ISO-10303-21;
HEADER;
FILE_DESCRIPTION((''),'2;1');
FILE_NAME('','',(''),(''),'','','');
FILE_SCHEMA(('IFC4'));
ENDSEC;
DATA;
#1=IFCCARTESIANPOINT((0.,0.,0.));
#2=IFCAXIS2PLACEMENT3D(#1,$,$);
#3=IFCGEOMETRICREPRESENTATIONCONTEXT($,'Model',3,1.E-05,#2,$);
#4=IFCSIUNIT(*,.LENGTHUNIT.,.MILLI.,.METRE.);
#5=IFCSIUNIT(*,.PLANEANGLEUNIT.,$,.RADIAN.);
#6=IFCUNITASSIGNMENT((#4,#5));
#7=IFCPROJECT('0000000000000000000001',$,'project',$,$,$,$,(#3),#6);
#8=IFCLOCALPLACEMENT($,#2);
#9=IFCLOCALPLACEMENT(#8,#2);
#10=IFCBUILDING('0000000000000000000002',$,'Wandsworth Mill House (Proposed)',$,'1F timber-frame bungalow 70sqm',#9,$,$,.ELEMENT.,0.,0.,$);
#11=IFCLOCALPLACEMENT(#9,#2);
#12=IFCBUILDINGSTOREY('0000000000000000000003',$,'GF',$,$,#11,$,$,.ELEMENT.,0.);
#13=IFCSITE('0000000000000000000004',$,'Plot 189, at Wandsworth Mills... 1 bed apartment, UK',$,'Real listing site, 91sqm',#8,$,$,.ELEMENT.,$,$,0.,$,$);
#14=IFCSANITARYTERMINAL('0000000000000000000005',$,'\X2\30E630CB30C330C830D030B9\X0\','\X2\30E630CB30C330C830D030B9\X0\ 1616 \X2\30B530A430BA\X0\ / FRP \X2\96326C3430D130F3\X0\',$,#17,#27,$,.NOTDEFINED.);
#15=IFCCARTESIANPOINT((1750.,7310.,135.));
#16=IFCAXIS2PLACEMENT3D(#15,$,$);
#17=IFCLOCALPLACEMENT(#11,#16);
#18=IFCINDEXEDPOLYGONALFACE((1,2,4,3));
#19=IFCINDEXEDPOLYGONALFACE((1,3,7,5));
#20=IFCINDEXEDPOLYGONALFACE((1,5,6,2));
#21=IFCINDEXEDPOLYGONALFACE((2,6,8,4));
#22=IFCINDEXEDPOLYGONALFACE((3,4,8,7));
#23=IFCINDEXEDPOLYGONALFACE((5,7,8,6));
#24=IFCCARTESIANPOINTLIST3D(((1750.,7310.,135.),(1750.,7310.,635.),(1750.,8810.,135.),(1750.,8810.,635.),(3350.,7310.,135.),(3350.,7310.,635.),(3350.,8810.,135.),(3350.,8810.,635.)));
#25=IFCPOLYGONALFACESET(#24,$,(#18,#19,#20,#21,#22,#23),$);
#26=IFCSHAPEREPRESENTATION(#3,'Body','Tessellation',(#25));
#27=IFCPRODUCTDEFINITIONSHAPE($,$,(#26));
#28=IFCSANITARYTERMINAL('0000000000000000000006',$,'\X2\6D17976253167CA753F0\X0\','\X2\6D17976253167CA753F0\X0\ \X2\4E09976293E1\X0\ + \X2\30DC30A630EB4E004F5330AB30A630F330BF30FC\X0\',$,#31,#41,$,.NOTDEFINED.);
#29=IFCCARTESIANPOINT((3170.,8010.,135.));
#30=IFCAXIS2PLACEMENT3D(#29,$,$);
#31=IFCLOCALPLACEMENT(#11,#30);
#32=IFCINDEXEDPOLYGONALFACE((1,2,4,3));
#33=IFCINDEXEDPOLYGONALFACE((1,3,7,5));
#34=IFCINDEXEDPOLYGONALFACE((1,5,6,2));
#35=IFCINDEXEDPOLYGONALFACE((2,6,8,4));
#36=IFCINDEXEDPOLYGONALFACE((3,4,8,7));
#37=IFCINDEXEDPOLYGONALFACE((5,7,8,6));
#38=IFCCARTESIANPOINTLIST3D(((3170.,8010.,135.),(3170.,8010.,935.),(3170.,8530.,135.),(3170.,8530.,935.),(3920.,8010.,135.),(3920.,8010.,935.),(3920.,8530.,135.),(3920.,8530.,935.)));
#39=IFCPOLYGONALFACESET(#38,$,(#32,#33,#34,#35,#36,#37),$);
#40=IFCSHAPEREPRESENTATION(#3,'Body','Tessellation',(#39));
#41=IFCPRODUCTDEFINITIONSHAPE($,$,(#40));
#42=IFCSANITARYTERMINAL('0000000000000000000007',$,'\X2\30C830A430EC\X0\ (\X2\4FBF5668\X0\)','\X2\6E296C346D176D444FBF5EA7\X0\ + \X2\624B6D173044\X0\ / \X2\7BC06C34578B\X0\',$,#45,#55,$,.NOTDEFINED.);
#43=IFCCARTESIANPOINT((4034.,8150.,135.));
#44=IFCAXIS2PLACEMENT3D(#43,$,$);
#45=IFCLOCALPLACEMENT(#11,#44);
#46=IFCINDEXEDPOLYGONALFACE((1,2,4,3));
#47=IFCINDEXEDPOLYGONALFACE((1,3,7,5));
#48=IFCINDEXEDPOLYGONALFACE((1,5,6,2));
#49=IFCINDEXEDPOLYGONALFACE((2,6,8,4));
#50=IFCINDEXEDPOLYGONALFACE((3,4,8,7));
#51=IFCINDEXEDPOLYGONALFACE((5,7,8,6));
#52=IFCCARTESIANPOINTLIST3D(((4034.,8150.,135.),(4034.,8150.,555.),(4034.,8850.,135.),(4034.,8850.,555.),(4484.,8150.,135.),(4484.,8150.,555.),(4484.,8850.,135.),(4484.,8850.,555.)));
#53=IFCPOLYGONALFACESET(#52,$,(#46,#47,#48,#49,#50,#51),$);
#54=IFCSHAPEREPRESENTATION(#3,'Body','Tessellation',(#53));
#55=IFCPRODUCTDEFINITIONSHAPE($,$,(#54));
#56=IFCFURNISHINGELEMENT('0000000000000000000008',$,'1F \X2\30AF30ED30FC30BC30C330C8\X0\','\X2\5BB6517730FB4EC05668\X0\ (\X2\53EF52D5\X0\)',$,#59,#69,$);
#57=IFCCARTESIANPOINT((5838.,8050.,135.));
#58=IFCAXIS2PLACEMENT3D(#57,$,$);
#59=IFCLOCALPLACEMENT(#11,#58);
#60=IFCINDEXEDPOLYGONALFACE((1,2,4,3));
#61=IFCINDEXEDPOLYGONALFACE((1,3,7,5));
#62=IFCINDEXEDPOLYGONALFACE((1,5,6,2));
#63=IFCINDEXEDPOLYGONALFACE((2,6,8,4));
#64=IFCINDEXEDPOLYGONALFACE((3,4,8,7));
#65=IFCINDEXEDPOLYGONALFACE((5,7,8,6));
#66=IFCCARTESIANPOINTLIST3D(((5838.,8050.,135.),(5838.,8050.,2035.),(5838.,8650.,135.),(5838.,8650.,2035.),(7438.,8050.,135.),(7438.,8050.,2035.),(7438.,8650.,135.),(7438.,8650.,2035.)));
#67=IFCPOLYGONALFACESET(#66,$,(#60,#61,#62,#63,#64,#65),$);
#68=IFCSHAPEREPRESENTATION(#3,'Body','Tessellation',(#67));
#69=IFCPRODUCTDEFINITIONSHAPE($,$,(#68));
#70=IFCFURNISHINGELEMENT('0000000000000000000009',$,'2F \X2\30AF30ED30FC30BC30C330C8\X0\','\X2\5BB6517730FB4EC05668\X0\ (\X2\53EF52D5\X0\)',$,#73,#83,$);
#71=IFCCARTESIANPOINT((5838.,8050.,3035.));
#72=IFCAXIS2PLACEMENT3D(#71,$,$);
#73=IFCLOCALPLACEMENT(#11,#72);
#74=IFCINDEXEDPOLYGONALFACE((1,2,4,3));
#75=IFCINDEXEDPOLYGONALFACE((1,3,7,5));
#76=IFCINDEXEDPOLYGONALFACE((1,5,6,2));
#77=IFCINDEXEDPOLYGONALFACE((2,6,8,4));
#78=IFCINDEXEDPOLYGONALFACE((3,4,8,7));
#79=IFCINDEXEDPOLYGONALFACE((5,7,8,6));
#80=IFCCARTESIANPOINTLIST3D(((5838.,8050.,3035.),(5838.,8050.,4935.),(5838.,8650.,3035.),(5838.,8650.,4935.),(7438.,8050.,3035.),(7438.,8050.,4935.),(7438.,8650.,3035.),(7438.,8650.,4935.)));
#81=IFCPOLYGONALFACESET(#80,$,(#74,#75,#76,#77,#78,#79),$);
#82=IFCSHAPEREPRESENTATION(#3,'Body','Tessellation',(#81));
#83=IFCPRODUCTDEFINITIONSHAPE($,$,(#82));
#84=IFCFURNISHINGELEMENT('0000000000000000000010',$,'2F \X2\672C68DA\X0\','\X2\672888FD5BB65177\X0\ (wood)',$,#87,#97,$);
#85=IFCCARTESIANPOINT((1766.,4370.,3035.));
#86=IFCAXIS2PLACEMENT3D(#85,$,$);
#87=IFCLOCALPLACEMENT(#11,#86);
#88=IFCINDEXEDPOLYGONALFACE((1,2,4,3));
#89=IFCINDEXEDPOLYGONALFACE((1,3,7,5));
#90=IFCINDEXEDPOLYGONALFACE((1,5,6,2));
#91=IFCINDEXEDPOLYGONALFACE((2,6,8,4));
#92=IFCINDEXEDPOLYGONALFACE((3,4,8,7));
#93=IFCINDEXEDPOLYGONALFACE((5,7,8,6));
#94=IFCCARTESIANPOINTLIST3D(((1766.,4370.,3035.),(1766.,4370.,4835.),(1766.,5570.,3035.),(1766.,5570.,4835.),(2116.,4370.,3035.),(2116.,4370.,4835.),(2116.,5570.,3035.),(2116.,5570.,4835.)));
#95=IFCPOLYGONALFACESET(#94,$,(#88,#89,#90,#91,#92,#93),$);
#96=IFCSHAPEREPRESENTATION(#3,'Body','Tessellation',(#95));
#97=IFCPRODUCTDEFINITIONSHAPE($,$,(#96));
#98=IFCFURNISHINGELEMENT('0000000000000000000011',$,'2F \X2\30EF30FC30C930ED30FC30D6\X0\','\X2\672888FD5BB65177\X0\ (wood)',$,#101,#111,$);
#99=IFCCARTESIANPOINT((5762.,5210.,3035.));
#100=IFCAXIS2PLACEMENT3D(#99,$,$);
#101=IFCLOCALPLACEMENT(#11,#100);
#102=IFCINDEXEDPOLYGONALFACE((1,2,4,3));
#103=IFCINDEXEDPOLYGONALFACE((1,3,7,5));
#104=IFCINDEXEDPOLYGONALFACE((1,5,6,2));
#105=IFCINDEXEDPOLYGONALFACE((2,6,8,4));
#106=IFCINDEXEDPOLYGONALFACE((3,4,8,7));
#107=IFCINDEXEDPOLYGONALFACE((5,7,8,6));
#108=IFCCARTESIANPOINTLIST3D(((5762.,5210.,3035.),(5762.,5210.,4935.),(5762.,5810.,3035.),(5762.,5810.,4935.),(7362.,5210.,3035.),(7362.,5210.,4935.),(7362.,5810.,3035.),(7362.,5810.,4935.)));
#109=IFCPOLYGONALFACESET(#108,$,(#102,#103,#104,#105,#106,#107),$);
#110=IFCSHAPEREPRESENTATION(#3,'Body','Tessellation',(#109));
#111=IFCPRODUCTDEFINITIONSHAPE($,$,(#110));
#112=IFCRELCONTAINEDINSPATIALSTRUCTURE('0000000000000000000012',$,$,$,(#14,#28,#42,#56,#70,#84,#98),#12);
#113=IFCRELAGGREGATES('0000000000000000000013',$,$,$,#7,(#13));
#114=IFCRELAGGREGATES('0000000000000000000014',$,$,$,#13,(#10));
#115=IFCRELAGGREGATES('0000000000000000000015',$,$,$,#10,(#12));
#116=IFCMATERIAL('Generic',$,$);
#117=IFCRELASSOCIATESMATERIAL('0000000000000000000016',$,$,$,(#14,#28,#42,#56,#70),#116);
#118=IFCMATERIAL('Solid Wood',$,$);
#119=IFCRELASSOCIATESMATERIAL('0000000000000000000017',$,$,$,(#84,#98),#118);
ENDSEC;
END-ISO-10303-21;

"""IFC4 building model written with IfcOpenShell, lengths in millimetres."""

from ifc_helpers import new_model, si_unit, frame, frame_2d, origin, place, context, project, spatial, rectangle, extrude, material, element, save


model = new_model("IFC4")

# Units and contexts
model_context = context("Model", 3, precision=1e-05, world=origin())
ifc_project = project(units=[si_unit("LENGTHUNIT", "METRE", prefix="MILLI"), si_unit("PLANEANGLEUNIT", "RADIAN")], contexts=[model_context])

# Site, building, storey
site_placement = place(None, origin())
site = spatial("IfcSite", under=ifc_project, at=site_placement, Name="Plot 189, at Wandsworth Mills... 1 bed apartment, UK", ObjectType="Real listing site, 91sqm", CompositionType="ELEMENT", RefElevation=0.0)
building_placement = place(site_placement, origin())
building = spatial("IfcBuilding", under=site, at=building_placement, Name="Wandsworth Mill House (Proposed)", ObjectType="1F timber-frame bungalow 70sqm", CompositionType="ELEMENT", ElevationOfRefHeight=0.0, ElevationOfTerrain=0.0)
storey_placement = place(building_placement, origin())
storey = spatial("IfcBuildingStorey", under=building, at=storey_placement, Name="GF", CompositionType="ELEMENT", Elevation=0.0)

# Shared definitions
ifc_material_1 = material(Name="Solid Wood")

# Shared definitions
ifc_material_2 = material(Name="Generic")

# Sanitary terminals
sanitary_terminal_1_placement = place(storey_placement, frame((1750.0, 7310.0, 135.0)))
element("IfcSanitaryTerminal", 1, at=sanitary_terminal_1_placement, inside=storey, material=ifc_material_2, Name="ユニットバス", Description="ユニットバス 1616 サイズ / FRP 防水パン", PredefinedType="NOTDEFINED", context=model_context, shape_type="SweptSolid", body=[
    extrude(rectangle(XDim=1600.0, YDim=1500.0, at=frame_2d((800.0, 750.0))), frame((1750.0, 7310.0, 135.0)), (0.0, 0.0, 1.0), 500.0),
])
sanitary_terminal_2_placement = place(storey_placement, frame((3170.0, 8010.0, 135.0)))
element("IfcSanitaryTerminal", 2, at=sanitary_terminal_2_placement, inside=storey, material=ifc_material_2, Name="洗面化粧台", Description="洗面化粧台 三面鏡 + ボウル一体カウンター", PredefinedType="NOTDEFINED", context=model_context, shape_type="SweptSolid", body=[
    extrude(rectangle(XDim=750.0, YDim=520.0, at=frame_2d((375.0, 260.0))), frame((3170.0, 8010.0, 135.0)), (0.0, 0.0, 1.0), 800.0),
])
sanitary_terminal_3_placement = place(storey_placement, frame((4034.0, 8150.0, 135.0)))
element("IfcSanitaryTerminal", 3, at=sanitary_terminal_3_placement, inside=storey, material=ifc_material_2, Name="トイレ (便器)", Description="温水洗浄便座 + 手洗い / 節水型", PredefinedType="NOTDEFINED", context=model_context, shape_type="SweptSolid", body=[
    extrude(rectangle(XDim=450.0, YDim=700.0, at=frame_2d((225.0, 350.0))), frame((4034.0, 8150.0, 135.0)), (0.0, 0.0, 1.0), 420.0),
])

# Furnishing elements
furnishing_1_placement = place(storey_placement, frame((5838.0, 8050.0, 135.0)))
element("IfcFurnishingElement", 4, at=furnishing_1_placement, inside=storey, material=ifc_material_2, Name="1F クローゼット", Description="家具・什器 (可動)", context=model_context, shape_type="SweptSolid", body=[
    extrude(rectangle(XDim=1600.0, YDim=600.0, at=frame_2d((800.0, 300.0))), frame((5838.0, 8050.0, 135.0)), (0.0, 0.0, 1.0), 1900.0),
])
furnishing_2_placement = place(storey_placement, frame((5838.0, 8050.0, 3035.0)))
element("IfcFurnishingElement", 5, at=furnishing_2_placement, inside=storey, material=ifc_material_2, Name="2F クローゼット", Description="家具・什器 (可動)", context=model_context, shape_type="SweptSolid", body=[
    extrude(rectangle(XDim=1600.0, YDim=600.0, at=frame_2d((800.0, 300.0))), frame((5838.0, 8050.0, 3035.0)), (0.0, 0.0, 1.0), 1900.0),
])
furnishing_3_placement = place(storey_placement, frame((1766.0, 4370.0, 3035.0)))
element("IfcFurnishingElement", 6, at=furnishing_3_placement, inside=storey, material=ifc_material_1, Name="2F 本棚", Description="木製家具 (wood)", context=model_context, shape_type="SweptSolid", body=[
    extrude(rectangle(XDim=350.0, YDim=1200.0, at=frame_2d((175.0, 600.0))), frame((1766.0, 4370.0, 3035.0)), (0.0, 0.0, 1.0), 1800.0),
])
furnishing_4_placement = place(storey_placement, frame((5762.0, 5210.0, 3035.0)))
element("IfcFurnishingElement", 7, at=furnishing_4_placement, inside=storey, material=ifc_material_1, Name="2F ワードローブ", Description="木製家具 (wood)", context=model_context, shape_type="SweptSolid", body=[
    extrude(rectangle(XDim=1600.0, YDim=600.0, at=frame_2d((800.0, 300.0))), frame((5762.0, 5210.0, 3035.0)), (0.0, 0.0, 1.0), 1900.0),
])

save(model, "model.ifc")
